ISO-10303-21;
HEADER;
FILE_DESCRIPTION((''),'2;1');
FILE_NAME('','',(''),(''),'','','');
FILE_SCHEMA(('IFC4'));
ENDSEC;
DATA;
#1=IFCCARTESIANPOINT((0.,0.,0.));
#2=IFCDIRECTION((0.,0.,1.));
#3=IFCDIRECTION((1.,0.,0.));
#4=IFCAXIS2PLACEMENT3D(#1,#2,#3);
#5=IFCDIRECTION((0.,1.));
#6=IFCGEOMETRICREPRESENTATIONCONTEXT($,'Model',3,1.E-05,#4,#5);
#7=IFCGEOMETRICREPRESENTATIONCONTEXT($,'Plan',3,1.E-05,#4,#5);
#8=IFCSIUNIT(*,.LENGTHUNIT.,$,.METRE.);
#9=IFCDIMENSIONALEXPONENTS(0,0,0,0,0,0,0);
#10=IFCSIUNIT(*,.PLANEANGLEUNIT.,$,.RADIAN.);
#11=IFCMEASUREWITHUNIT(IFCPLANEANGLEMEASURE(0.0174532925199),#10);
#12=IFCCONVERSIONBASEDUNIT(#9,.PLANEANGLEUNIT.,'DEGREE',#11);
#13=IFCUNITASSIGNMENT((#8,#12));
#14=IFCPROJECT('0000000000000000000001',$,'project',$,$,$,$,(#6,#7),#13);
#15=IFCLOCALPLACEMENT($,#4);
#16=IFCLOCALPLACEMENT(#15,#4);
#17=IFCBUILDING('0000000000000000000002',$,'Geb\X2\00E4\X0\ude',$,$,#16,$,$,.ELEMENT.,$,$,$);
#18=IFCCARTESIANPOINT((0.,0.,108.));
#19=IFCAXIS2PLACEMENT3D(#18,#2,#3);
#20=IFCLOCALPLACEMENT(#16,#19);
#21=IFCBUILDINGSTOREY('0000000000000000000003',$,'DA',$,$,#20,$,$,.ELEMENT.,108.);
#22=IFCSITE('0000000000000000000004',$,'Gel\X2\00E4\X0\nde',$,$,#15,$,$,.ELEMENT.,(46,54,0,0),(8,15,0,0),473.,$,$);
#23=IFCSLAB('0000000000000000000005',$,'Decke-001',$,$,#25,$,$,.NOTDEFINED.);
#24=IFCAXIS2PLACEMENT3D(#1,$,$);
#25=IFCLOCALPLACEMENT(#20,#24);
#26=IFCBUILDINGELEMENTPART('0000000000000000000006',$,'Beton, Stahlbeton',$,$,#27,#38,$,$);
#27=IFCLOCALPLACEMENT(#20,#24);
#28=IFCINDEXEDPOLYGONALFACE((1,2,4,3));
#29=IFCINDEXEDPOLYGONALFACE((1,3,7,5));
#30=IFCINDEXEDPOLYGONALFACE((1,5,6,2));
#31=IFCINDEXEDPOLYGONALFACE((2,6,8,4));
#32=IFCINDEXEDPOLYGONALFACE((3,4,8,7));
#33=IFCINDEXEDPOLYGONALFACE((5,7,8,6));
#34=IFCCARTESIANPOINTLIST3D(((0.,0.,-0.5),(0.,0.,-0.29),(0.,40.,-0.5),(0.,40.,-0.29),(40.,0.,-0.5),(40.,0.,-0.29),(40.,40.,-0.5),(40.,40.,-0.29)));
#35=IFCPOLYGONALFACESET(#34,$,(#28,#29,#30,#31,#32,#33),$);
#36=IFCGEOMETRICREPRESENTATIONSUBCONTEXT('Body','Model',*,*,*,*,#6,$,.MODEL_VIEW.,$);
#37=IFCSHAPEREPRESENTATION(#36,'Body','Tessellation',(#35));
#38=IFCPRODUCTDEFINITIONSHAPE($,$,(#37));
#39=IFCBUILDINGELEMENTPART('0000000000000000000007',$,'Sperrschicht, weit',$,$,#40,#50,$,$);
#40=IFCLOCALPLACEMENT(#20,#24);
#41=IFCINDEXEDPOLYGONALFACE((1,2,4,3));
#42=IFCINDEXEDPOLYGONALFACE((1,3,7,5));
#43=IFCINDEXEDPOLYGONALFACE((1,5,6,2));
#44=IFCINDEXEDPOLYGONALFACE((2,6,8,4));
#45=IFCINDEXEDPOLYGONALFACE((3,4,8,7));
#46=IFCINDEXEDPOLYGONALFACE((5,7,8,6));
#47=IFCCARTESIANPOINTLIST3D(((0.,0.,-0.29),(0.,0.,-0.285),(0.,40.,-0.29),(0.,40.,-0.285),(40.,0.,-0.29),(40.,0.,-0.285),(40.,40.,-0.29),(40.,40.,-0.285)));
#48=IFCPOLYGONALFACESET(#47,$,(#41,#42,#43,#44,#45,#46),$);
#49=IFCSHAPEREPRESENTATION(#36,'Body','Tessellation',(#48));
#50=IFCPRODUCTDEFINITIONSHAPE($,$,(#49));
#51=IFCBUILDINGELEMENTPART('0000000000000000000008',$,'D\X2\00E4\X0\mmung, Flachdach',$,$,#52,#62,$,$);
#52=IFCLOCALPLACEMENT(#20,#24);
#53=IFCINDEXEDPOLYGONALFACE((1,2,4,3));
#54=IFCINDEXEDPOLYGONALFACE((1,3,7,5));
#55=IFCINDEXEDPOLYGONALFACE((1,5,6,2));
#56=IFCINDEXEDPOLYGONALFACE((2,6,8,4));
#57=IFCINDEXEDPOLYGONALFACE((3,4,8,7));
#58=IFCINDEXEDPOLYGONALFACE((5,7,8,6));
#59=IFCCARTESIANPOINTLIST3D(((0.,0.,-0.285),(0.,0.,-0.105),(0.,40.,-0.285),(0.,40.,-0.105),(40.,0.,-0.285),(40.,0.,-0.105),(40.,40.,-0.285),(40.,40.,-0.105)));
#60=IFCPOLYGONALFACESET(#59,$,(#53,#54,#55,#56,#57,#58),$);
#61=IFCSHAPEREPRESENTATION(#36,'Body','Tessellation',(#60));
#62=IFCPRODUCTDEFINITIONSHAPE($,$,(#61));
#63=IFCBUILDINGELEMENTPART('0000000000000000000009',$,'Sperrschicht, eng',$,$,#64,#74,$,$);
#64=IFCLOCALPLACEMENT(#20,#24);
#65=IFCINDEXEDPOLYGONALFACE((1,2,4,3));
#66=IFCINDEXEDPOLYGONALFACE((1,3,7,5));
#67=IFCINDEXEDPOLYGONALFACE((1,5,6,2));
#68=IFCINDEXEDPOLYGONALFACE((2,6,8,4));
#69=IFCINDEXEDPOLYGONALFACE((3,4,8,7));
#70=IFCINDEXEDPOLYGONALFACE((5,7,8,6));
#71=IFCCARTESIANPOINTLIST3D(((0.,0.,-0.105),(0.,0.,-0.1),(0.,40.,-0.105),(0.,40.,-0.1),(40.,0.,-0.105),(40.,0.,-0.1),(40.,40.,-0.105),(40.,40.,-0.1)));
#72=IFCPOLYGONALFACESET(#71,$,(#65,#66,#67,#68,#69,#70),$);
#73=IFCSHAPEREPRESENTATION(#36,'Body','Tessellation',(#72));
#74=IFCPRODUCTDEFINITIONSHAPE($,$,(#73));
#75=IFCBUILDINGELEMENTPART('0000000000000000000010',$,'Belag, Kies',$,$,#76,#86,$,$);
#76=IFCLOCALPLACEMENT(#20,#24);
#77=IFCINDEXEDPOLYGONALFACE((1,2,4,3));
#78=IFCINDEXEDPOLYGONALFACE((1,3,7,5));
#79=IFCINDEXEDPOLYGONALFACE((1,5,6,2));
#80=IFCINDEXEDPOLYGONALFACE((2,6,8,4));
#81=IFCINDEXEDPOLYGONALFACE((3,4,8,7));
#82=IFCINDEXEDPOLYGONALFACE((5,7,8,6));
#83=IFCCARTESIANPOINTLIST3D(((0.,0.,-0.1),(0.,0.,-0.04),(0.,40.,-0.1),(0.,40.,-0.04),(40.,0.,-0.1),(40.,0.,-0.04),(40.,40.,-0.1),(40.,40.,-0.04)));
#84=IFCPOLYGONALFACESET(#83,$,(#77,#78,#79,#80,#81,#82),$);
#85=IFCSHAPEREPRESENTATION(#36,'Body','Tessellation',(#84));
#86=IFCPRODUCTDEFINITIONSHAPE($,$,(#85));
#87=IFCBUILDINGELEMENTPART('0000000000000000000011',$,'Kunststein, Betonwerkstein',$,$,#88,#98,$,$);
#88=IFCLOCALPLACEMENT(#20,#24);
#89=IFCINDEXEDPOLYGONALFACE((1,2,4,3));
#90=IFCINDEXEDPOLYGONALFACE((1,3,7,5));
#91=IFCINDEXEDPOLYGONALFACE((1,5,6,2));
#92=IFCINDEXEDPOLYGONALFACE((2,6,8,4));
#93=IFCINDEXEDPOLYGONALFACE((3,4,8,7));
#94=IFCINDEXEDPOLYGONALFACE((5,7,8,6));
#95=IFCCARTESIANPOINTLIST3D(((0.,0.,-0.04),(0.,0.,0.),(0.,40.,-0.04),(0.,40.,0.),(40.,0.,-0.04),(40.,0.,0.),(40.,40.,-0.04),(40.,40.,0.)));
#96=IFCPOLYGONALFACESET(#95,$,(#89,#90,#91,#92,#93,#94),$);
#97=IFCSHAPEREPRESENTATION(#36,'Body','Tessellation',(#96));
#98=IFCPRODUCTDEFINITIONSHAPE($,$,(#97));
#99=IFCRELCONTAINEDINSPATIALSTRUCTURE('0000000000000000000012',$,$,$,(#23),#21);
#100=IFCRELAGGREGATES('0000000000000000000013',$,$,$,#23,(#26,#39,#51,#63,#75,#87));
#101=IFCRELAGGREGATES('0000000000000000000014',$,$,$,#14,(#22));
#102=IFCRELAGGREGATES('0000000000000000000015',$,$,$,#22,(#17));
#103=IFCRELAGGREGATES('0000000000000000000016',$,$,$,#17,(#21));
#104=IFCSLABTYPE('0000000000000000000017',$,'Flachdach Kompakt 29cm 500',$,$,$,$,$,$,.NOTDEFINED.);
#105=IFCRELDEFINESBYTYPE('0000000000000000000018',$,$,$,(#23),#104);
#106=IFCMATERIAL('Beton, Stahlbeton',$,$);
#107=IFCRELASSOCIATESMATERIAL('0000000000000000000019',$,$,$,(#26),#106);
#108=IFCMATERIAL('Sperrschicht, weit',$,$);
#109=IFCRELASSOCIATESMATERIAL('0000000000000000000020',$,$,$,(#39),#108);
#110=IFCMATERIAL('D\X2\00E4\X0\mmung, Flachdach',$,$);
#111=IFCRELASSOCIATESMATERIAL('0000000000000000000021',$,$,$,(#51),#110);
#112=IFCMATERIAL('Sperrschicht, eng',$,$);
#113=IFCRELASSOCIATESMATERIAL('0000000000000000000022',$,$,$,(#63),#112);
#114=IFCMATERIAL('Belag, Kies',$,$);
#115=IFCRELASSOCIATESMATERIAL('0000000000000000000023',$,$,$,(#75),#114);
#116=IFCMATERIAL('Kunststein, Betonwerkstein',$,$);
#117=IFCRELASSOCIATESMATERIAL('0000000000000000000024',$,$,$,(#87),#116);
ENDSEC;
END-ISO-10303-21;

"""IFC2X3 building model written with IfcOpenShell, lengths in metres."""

from ifc_helpers import new_model, entity, si_unit, converted_unit, direction, frame, origin_with_axes, place, context, subcontext, project, spatial, polyline, outline, extrude, material, type_object, element, aggregate, save


model = new_model("IFC2X3")

# Units and contexts
model_context = context("Model", 3, precision=1e-05, world=origin_with_axes(), true_north=direction((0.0, 1.0)))
plan_context = context("Plan", 3, precision=1e-05, world=origin_with_axes(), true_north=direction((0.0, 1.0)))
body_context = subcontext(model_context, "Body", "Model", "MODEL_VIEW")
ifc_project = project(units=[si_unit("LENGTHUNIT", "METRE"), converted_unit("PLANEANGLEUNIT", "DEGREE", entity("IfcPlaneAngleMeasure", 0.0174532925199), si_unit("PLANEANGLEUNIT", "RADIAN"), dimensions=[0, 0, 0, 0, 0, 0, 0])], contexts=[model_context, plan_context])

# Site, building, storey
site_placement = place(None, origin_with_axes())
site = spatial("IfcSite", under=ifc_project, at=site_placement, Name="Gelände", CompositionType="ELEMENT", RefLatitude=(46, 54, 0, 0), RefLongitude=(8, 15, 0, 0), RefElevation=473.0)
building_placement = place(site_placement, origin_with_axes())
building = spatial("IfcBuilding", under=site, at=building_placement, Name="Gebäude", CompositionType="ELEMENT")
storey_placement = place(building_placement, frame((0.0, 0.0, 108.0), z_axis=(0.0, 0.0, 1.0), x_axis=(1.0, 0.0, 0.0)))
storey = spatial("IfcBuildingStorey", under=building, at=storey_placement, Name="DA", CompositionType="ELEMENT", Elevation=108.0)

# Slab, building element parts
slab_type = type_object("IfcSlabType", Name="Flachdach Kompakt 29cm 500", PredefinedType="NOTDEFINED")
slab_placement = place(storey_placement, origin_with_axes())
slab = element("IfcSlab", 1, at=slab_placement, inside=storey, type_object=slab_type, Name="Decke-001", PredefinedType="NOTDEFINED")
ifc_material_1 = material(Name="Beton, Stahlbeton")
building_element_part_1_placement = place(slab_placement, origin_with_axes())
building_element_part_1 = element("IfcBuildingElementPart", 2, at=building_element_part_1_placement, material=ifc_material_1, Name="Beton, Stahlbeton", context=body_context, shape_type="SweptSolid", body=[
    extrude(outline(polyline([(0.0, 0.0), (40.0, 0.0), (40.0, 40.0), (0.0, 40.0), (0.0, 0.0)])), frame((0.0, 0.0, -0.5), z_axis=(0.0, 0.0, 1.0), x_axis=(1.0, 0.0, 0.0)), (0.0, 0.0, 1.0), 0.21),
])
ifc_material_2 = material(Name="Sperrschicht, weit")
building_element_part_2_placement = place(slab_placement, origin_with_axes())
building_element_part_2 = element("IfcBuildingElementPart", 3, at=building_element_part_2_placement, material=ifc_material_2, Name="Sperrschicht, weit", context=body_context, shape_type="SweptSolid", body=[
    extrude(outline(polyline([(0.0, 0.0), (40.0, 0.0), (40.0, 40.0), (0.0, 40.0), (0.0, 0.0)])), frame((0.0, 0.0, -0.29), z_axis=(0.0, 0.0, 1.0), x_axis=(1.0, 0.0, 0.0)), (0.0, 0.0, 1.0), 0.005),
])
ifc_material_3 = material(Name="Dämmung, Flachdach")
building_element_part_3_placement = place(slab_placement, origin_with_axes())
building_element_part_3 = element("IfcBuildingElementPart", 4, at=building_element_part_3_placement, material=ifc_material_3, Name="Dämmung, Flachdach", context=body_context, shape_type="SweptSolid", body=[
    extrude(outline(polyline([(0.0, 0.0), (40.0, 0.0), (40.0, 40.0), (0.0, 40.0), (0.0, 0.0)])), frame((0.0, 0.0, -0.285), z_axis=(0.0, 0.0, 1.0), x_axis=(1.0, 0.0, 0.0)), (0.0, 0.0, 1.0), 0.18),
])
ifc_material_4 = material(Name="Sperrschicht, eng")
building_element_part_4_placement = place(slab_placement, origin_with_axes())
building_element_part_4 = element("IfcBuildingElementPart", 5, at=building_element_part_4_placement, material=ifc_material_4, Name="Sperrschicht, eng", context=body_context, shape_type="SweptSolid", body=[
    extrude(outline(polyline([(0.0, 0.0), (40.0, 0.0), (40.0, 40.0), (0.0, 40.0), (0.0, 0.0)])), frame((0.0, 0.0, -0.105), z_axis=(0.0, 0.0, 1.0), x_axis=(1.0, 0.0, 0.0)), (0.0, 0.0, 1.0), 0.005),
])
ifc_material_5 = material(Name="Belag, Kies")
building_element_part_5_placement = place(slab_placement, origin_with_axes())
building_element_part_5 = element("IfcBuildingElementPart", 6, at=building_element_part_5_placement, material=ifc_material_5, Name="Belag, Kies", context=body_context, shape_type="SweptSolid", body=[
    extrude(outline(polyline([(0.0, 0.0), (40.0, 0.0), (40.0, 40.0), (0.0, 40.0), (0.0, 0.0)])), frame((0.0, 0.0, -0.1), z_axis=(0.0, 0.0, 1.0), x_axis=(1.0, 0.0, 0.0)), (0.0, 0.0, 1.0), 0.06),
])
ifc_material_6 = material(Name="Kunststein, Betonwerkstein")
building_element_part_6_placement = place(slab_placement, origin_with_axes())
building_element_part_6 = element("IfcBuildingElementPart", 7, at=building_element_part_6_placement, material=ifc_material_6, Name="Kunststein, Betonwerkstein", context=body_context, shape_type="SweptSolid", body=[
    extrude(outline(polyline([(0.0, 0.0), (40.0, 0.0), (40.0, 40.0), (0.0, 40.0), (0.0, 0.0)])), frame((0.0, 0.0, -0.04), z_axis=(0.0, 0.0, 1.0), x_axis=(1.0, 0.0, 0.0)), (0.0, 0.0, 1.0), 0.04),
])
aggregate(slab, [building_element_part_1, building_element_part_2, building_element_part_3, building_element_part_4, building_element_part_5, building_element_part_6])

save(model, "model.ifc")
